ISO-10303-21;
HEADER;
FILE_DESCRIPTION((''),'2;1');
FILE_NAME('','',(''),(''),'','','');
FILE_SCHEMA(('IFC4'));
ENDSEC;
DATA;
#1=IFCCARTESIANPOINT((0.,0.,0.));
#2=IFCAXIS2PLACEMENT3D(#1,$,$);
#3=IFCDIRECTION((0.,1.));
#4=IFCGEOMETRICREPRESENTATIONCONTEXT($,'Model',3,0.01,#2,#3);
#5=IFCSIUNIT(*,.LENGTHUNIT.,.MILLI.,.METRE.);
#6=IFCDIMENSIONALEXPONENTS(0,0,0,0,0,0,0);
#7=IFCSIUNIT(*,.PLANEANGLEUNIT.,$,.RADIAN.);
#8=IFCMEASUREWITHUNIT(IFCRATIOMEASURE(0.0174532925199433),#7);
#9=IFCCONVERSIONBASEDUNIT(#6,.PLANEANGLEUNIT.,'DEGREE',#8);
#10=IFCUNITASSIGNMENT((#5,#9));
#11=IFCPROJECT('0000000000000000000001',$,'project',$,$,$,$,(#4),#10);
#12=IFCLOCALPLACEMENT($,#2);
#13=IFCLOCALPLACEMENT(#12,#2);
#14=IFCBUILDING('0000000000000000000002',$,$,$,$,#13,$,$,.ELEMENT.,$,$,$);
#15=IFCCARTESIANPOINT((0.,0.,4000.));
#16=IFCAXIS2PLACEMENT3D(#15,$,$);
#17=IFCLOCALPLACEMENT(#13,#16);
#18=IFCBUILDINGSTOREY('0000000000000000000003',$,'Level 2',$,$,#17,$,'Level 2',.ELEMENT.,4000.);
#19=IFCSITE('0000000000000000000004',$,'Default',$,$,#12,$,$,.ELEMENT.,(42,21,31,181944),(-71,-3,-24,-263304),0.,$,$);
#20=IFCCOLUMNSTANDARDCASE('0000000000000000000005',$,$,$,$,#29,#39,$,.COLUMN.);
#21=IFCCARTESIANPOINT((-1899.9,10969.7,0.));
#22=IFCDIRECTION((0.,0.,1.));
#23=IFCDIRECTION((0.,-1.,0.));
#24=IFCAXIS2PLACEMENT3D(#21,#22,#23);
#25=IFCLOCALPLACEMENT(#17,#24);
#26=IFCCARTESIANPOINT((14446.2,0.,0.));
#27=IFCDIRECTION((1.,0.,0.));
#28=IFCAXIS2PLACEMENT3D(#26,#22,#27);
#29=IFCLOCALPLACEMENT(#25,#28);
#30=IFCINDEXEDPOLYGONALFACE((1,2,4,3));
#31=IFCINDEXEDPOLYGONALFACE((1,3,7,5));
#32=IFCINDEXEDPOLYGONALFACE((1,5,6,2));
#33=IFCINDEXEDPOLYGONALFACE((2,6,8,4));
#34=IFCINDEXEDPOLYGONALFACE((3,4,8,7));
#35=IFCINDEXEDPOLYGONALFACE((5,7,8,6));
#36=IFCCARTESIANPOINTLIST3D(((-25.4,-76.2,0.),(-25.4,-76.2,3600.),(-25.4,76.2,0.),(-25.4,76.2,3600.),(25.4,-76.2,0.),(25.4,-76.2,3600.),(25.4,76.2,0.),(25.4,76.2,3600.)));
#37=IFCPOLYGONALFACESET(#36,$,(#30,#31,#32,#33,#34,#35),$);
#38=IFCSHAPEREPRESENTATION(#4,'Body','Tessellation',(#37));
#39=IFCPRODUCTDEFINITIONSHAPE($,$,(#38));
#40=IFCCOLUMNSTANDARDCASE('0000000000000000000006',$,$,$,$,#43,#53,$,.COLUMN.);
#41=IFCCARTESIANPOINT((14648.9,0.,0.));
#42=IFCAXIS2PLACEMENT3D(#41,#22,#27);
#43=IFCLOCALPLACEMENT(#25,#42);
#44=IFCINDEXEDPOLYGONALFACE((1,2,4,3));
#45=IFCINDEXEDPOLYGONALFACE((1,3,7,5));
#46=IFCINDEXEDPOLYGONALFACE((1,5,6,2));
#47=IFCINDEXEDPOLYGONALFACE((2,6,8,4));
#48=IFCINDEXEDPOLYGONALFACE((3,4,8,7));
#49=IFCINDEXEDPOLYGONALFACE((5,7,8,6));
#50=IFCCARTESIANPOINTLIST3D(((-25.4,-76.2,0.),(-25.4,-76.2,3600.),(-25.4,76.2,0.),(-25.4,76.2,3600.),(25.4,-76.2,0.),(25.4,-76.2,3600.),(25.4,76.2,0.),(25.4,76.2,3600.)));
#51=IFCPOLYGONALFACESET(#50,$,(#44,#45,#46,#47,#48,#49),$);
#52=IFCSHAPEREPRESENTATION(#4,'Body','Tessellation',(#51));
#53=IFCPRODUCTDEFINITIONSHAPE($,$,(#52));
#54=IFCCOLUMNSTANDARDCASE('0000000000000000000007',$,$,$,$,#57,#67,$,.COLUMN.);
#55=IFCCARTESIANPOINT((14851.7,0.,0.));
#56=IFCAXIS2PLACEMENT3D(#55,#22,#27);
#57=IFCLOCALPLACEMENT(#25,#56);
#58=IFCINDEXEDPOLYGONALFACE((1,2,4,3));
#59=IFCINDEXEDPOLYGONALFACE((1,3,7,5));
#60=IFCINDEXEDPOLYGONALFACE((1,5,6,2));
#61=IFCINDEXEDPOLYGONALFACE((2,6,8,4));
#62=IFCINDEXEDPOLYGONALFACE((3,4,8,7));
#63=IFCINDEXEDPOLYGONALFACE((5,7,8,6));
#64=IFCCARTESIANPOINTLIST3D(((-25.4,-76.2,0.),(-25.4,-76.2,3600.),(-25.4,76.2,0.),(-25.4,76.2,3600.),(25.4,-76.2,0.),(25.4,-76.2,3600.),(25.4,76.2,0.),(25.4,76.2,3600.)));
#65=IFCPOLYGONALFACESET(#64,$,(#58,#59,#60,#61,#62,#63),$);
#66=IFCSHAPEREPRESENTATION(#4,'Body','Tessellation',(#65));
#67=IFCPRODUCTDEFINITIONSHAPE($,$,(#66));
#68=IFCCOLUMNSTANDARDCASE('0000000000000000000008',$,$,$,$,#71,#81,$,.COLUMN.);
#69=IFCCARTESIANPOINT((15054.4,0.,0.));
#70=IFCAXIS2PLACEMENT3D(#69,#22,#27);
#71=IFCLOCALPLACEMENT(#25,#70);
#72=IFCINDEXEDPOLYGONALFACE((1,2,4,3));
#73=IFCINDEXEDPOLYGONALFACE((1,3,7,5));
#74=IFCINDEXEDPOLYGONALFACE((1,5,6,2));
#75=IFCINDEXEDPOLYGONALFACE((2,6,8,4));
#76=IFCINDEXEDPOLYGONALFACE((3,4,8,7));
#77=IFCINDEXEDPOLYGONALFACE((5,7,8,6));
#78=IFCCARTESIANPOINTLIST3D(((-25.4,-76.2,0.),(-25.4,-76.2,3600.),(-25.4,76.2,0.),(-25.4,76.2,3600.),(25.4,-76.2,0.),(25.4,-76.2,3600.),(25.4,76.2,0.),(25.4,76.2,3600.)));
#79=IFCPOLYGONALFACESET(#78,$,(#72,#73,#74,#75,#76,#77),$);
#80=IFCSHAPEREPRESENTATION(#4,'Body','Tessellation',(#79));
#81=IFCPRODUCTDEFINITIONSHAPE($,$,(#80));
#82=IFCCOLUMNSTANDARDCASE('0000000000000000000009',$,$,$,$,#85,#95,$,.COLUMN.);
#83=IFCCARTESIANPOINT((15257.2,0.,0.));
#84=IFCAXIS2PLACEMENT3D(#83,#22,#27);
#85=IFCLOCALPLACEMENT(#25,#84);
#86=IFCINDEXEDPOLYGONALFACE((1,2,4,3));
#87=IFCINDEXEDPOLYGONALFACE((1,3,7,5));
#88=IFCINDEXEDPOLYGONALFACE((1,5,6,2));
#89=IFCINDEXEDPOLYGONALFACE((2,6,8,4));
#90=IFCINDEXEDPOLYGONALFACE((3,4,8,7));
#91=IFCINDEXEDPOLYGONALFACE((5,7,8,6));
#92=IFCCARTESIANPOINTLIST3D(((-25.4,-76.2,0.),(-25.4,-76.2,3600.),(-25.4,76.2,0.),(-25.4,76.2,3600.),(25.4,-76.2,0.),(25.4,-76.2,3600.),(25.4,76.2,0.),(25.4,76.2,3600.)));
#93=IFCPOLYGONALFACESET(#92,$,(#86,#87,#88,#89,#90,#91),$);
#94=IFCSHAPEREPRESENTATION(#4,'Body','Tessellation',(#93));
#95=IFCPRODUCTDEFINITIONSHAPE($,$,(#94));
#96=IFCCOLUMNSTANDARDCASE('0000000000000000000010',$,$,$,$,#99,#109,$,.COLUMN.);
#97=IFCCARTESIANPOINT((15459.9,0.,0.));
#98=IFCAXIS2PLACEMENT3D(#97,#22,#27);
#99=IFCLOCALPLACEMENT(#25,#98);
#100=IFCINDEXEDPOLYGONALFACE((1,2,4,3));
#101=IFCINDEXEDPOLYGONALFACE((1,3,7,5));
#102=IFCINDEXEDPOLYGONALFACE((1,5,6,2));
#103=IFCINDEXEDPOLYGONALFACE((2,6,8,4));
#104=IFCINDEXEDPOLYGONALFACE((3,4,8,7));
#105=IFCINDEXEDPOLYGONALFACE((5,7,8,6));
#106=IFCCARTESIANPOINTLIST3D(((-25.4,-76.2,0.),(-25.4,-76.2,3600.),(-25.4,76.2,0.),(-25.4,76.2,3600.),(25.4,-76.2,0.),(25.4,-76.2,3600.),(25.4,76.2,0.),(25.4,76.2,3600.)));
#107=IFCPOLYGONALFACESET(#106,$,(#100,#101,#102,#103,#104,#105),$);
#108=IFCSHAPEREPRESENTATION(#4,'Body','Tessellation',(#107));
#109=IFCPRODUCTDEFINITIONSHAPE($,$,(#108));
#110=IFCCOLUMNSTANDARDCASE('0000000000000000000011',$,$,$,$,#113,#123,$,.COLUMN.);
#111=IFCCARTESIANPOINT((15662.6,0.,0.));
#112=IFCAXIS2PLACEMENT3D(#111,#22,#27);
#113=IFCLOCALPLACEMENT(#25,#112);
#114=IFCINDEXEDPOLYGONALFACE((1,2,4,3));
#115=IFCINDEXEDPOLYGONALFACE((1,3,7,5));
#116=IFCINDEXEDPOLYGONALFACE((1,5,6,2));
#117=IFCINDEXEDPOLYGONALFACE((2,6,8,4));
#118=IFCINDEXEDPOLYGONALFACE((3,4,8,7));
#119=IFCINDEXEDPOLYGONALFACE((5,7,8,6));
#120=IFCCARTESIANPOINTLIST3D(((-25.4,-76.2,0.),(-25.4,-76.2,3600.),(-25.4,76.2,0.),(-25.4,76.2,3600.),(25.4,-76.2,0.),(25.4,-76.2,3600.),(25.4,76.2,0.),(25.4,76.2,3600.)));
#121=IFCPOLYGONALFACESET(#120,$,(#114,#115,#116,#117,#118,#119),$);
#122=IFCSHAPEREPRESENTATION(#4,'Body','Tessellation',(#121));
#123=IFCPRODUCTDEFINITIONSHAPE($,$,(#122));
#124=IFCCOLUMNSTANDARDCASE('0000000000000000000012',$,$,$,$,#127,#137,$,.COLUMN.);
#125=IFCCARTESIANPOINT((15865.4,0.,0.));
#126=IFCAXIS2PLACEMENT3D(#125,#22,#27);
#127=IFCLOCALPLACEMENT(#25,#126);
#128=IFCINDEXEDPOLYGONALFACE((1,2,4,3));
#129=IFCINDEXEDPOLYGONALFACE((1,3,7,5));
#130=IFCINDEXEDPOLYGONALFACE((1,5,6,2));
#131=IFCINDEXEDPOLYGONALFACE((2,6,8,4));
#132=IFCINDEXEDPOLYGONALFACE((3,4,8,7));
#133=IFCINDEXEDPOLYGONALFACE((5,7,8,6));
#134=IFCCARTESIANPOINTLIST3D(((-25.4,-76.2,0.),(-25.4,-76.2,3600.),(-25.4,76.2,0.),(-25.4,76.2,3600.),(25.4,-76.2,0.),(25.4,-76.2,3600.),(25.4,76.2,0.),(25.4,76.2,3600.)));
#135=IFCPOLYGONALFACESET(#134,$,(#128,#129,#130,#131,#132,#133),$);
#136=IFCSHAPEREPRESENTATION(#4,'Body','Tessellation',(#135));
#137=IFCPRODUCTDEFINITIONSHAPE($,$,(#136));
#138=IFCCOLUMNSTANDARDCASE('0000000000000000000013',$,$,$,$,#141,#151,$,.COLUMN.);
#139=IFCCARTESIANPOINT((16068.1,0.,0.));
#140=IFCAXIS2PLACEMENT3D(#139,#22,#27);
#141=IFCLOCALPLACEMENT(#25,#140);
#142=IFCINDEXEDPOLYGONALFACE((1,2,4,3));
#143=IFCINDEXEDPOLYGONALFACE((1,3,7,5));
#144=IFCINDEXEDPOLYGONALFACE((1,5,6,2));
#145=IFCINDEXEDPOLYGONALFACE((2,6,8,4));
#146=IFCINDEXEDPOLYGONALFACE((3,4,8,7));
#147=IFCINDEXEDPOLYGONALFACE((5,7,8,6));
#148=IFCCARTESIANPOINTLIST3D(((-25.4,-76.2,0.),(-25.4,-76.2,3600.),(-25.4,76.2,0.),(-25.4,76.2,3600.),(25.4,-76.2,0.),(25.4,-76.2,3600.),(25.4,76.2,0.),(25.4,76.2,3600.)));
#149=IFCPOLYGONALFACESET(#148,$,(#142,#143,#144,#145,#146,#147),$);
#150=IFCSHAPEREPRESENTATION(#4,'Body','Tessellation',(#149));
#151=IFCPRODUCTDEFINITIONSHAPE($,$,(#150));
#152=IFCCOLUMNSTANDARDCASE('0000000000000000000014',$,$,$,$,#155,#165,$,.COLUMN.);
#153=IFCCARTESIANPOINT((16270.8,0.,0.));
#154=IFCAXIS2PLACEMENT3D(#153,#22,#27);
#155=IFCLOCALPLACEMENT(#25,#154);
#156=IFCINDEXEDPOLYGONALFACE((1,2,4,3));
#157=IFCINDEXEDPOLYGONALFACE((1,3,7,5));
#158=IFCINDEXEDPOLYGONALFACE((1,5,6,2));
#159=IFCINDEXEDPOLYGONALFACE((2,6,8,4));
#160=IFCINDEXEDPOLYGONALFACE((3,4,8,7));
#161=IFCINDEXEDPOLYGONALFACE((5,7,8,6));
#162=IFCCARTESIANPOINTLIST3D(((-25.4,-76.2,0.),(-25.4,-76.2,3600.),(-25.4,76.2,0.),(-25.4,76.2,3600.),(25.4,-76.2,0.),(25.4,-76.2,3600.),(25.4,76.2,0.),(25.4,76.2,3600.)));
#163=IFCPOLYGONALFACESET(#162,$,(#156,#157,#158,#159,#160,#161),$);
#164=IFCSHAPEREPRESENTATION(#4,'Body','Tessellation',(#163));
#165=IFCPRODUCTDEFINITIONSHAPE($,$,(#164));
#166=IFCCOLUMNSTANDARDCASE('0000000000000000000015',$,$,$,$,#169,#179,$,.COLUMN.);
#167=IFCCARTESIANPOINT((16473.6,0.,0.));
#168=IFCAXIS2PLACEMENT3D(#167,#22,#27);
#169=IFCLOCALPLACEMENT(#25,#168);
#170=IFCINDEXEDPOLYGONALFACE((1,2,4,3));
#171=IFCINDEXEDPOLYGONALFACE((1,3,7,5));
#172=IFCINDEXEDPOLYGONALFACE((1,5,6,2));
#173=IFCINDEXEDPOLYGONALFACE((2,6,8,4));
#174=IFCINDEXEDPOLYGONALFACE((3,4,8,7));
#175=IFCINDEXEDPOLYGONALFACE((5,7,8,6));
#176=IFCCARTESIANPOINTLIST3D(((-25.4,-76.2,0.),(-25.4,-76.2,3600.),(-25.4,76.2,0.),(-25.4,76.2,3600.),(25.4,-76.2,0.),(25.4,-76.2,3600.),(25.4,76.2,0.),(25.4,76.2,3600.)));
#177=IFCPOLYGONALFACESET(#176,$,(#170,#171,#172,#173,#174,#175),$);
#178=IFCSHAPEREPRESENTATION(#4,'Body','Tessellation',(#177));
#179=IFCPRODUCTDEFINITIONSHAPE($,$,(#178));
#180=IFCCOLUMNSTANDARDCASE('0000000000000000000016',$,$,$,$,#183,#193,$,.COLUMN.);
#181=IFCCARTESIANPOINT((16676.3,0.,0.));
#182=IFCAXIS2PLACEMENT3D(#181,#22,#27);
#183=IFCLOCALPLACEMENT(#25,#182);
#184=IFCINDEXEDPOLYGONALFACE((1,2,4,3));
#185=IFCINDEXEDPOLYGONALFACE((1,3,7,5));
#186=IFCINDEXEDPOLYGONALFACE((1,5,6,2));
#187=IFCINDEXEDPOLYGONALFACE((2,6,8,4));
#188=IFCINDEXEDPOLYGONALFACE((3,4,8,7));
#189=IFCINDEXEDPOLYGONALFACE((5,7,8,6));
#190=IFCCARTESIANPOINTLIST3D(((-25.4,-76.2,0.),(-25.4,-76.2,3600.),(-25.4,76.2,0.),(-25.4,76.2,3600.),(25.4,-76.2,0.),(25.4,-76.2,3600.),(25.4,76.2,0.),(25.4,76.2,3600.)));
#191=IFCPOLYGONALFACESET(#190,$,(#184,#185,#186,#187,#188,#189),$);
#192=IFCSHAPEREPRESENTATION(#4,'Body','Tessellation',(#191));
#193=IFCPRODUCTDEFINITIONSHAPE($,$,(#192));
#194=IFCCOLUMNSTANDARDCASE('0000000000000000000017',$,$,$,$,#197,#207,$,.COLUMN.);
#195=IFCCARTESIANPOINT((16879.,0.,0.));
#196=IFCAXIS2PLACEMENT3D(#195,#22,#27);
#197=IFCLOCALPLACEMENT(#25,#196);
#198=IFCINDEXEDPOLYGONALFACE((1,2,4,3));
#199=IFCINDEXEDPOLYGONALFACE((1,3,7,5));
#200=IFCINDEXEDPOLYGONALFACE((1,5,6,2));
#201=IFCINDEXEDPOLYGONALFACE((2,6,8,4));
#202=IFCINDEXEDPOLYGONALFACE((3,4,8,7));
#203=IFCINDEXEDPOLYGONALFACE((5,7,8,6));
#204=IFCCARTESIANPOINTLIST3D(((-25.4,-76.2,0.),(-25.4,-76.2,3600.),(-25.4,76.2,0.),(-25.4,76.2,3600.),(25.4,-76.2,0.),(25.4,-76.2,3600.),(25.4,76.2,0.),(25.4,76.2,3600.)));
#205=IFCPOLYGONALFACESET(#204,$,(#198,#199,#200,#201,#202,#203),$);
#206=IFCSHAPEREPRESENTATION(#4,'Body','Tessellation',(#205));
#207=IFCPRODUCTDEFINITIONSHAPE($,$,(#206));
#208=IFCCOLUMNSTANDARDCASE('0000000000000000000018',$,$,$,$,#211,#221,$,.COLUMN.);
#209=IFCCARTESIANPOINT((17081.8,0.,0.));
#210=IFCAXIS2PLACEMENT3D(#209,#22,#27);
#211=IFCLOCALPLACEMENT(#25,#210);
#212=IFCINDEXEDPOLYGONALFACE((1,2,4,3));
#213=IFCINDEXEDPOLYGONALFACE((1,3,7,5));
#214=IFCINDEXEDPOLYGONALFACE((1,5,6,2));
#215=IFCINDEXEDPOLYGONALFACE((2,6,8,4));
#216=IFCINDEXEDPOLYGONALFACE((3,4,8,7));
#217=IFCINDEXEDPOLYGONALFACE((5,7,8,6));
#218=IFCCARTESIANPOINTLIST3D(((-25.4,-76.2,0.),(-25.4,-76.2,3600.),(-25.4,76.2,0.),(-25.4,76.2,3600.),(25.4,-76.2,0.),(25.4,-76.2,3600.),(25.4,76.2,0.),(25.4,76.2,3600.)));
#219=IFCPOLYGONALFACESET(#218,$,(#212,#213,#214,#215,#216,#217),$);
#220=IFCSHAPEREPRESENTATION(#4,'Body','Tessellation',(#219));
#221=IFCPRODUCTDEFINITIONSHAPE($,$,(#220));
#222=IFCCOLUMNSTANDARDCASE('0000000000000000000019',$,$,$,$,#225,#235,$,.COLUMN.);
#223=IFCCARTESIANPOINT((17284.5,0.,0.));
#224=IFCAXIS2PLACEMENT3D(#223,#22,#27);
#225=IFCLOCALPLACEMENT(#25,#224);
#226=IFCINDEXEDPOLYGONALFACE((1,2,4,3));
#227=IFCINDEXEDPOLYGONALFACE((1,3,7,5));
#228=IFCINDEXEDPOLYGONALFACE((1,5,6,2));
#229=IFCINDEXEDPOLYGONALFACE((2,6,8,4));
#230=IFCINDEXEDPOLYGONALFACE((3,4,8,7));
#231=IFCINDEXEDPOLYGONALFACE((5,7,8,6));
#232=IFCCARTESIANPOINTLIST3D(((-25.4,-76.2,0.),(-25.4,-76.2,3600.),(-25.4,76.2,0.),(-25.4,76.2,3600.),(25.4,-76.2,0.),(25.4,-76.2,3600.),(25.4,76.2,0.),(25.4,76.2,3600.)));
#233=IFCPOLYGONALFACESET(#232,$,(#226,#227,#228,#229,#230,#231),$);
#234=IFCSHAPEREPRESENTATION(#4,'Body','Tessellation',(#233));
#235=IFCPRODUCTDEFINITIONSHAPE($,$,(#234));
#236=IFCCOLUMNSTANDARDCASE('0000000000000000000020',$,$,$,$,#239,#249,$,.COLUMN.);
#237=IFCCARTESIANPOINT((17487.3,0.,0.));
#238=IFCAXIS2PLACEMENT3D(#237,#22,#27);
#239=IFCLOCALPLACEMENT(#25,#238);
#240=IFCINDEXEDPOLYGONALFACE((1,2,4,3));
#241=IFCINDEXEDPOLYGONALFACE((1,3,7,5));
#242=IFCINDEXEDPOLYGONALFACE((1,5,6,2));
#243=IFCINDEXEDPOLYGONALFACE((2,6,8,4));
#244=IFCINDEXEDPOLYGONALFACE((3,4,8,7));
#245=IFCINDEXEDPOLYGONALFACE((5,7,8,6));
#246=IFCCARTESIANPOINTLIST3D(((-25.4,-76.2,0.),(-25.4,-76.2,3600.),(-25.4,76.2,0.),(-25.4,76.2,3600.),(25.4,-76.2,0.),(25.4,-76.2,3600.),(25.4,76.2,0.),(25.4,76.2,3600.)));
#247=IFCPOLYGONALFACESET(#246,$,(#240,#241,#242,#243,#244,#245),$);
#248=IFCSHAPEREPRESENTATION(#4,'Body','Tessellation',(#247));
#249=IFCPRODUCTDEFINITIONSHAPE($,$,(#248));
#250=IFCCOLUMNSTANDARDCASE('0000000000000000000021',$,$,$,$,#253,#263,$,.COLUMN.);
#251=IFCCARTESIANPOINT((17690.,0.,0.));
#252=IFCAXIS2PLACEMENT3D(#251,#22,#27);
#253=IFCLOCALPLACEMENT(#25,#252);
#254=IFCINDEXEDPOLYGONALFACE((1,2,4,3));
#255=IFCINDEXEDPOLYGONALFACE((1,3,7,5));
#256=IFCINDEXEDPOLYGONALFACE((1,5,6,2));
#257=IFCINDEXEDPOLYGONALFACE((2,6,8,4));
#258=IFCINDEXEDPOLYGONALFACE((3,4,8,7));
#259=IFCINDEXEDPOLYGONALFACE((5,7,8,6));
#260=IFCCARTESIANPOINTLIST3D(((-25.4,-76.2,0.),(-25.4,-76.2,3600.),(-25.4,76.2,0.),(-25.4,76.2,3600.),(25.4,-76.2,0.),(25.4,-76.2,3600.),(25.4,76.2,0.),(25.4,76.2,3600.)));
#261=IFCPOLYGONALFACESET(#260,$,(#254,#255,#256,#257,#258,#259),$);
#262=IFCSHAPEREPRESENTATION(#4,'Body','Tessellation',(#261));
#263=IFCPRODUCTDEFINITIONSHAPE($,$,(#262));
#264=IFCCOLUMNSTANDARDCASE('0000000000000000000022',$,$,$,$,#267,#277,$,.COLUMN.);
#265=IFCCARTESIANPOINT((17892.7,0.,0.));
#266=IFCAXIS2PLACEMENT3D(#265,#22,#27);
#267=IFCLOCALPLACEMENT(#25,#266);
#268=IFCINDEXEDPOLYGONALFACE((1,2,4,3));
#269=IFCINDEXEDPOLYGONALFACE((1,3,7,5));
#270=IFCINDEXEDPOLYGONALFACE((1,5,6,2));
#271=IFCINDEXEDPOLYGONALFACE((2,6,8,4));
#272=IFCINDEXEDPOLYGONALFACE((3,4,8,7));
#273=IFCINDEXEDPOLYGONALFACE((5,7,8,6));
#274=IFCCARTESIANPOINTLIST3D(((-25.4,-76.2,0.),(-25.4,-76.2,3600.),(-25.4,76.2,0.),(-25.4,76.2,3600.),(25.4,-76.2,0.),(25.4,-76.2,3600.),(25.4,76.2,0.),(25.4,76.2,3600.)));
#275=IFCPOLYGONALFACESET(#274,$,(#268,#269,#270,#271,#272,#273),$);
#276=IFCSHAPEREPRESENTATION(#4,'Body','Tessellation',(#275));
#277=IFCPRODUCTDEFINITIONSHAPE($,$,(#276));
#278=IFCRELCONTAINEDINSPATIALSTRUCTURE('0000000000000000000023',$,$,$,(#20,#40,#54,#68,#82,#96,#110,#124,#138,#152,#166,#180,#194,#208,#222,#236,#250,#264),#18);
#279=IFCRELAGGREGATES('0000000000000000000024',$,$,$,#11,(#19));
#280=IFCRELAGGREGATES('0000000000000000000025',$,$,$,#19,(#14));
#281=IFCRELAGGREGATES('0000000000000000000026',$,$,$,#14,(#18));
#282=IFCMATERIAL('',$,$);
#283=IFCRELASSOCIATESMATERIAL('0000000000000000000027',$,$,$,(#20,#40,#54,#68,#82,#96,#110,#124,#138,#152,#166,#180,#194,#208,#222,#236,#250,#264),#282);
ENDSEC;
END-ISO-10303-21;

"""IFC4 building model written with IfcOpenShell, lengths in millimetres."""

from ifc_helpers import new_model, entity, si_unit, converted_unit, direction, frame, origin, place, context, project, spatial, rectangle, extrude, material, element, save


model = new_model("IFC4")

# Units and contexts
model_context = context("Model", 3, precision=0.01, world=origin(), true_north=direction((0.0, 1.0)))
ifc_project = project(units=[si_unit("LENGTHUNIT", "METRE", prefix="MILLI"), converted_unit("PLANEANGLEUNIT", "DEGREE", entity("IfcRatioMeasure", 0.0174532925199433), si_unit("PLANEANGLEUNIT", "RADIAN"), dimensions=[0, 0, 0, 0, 0, 0, 0])], contexts=[model_context])

# Site, building, storey
site_placement = place(None, origin())
site = spatial("IfcSite", under=ifc_project, at=site_placement, Name="Default", CompositionType="ELEMENT", RefLatitude=(42, 21, 31, 181944), RefLongitude=(-71, -3, -24, -263304), RefElevation=0.0)
building_placement = place(site_placement, origin())
building = spatial("IfcBuilding", under=site, at=building_placement, CompositionType="ELEMENT")
storey_placement = place(building_placement, frame((0.0, 0.0, 4000.0)))
storey = spatial("IfcBuildingStorey", under=building, at=storey_placement, Name="Level 2", LongName="Level 2", CompositionType="ELEMENT", Elevation=4000.0)

# Columns
ifc_material = material(Name="")
placement = place(storey_placement, frame((-1899.9, 10969.7, 0.0), z_axis=(0.0, 0.0, 1.0), x_axis=(0.0, -1.0, 0.0)))
for number, where, z_axis, x_axis in (
    (1, (14446.2, 0.0, 0.0), (0.0, 0.0, 1.0), (1.0, 0.0, 0.0)),
    (2, (14648.9, 0.0, 0.0), (0.0, 0.0, 1.0), (1.0, 0.0, 0.0)),
    (3, (14851.7, 0.0, 0.0), (0.0, 0.0, 1.0), (1.0, 0.0, 0.0)),
    (4, (15054.4, 0.0, 0.0), (0.0, 0.0, 1.0), (1.0, 0.0, 0.0)),
    (5, (15257.2, 0.0, 0.0), (0.0, 0.0, 1.0), (1.0, 0.0, 0.0)),
    (6, (15459.9, 0.0, 0.0), (0.0, 0.0, 1.0), (1.0, 0.0, 0.0)),
    (7, (15662.6, 0.0, 0.0), (0.0, 0.0, 1.0), (1.0, 0.0, 0.0)),
    (8, (15865.4, 0.0, 0.0), (0.0, 0.0, 1.0), (1.0, 0.0, 0.0)),
    (9, (16068.1, 0.0, 0.0), (0.0, 0.0, 1.0), (1.0, 0.0, 0.0)),
    (10, (16270.8, 0.0, 0.0), (0.0, 0.0, 1.0), (1.0, 0.0, 0.0)),
    (11, (16473.6, 0.0, 0.0), (0.0, 0.0, 1.0), (1.0, 0.0, 0.0)),
    (12, (16676.3, 0.0, 0.0), (0.0, 0.0, 1.0), (1.0, 0.0, 0.0)),
    (13, (16879.0, 0.0, 0.0), (0.0, 0.0, 1.0), (1.0, 0.0, 0.0)),
    (14, (17081.8, 0.0, 0.0), (0.0, 0.0, 1.0), (1.0, 0.0, 0.0)),
    (15, (17284.5, 0.0, 0.0), (0.0, 0.0, 1.0), (1.0, 0.0, 0.0)),
    (16, (17487.3, 0.0, 0.0), (0.0, 0.0, 1.0), (1.0, 0.0, 0.0)),
    (17, (17690.0, 0.0, 0.0), (0.0, 0.0, 1.0), (1.0, 0.0, 0.0)),
    (18, (17892.7, 0.0, 0.0), (0.0, 0.0, 1.0), (1.0, 0.0, 0.0)),
):
    element("IfcColumnStandardCase", number, at=place(placement, frame(where, z_axis=z_axis, x_axis=x_axis)), inside=storey, material=ifc_material, PredefinedType="COLUMN", context=model_context, shape_type="SweptSolid", body=[
        extrude(rectangle(XDim=50.8, YDim=152.4), origin(), (0.0, 0.0, 1.0), 3600.0),
    ])

save(model, "model.ifc")
